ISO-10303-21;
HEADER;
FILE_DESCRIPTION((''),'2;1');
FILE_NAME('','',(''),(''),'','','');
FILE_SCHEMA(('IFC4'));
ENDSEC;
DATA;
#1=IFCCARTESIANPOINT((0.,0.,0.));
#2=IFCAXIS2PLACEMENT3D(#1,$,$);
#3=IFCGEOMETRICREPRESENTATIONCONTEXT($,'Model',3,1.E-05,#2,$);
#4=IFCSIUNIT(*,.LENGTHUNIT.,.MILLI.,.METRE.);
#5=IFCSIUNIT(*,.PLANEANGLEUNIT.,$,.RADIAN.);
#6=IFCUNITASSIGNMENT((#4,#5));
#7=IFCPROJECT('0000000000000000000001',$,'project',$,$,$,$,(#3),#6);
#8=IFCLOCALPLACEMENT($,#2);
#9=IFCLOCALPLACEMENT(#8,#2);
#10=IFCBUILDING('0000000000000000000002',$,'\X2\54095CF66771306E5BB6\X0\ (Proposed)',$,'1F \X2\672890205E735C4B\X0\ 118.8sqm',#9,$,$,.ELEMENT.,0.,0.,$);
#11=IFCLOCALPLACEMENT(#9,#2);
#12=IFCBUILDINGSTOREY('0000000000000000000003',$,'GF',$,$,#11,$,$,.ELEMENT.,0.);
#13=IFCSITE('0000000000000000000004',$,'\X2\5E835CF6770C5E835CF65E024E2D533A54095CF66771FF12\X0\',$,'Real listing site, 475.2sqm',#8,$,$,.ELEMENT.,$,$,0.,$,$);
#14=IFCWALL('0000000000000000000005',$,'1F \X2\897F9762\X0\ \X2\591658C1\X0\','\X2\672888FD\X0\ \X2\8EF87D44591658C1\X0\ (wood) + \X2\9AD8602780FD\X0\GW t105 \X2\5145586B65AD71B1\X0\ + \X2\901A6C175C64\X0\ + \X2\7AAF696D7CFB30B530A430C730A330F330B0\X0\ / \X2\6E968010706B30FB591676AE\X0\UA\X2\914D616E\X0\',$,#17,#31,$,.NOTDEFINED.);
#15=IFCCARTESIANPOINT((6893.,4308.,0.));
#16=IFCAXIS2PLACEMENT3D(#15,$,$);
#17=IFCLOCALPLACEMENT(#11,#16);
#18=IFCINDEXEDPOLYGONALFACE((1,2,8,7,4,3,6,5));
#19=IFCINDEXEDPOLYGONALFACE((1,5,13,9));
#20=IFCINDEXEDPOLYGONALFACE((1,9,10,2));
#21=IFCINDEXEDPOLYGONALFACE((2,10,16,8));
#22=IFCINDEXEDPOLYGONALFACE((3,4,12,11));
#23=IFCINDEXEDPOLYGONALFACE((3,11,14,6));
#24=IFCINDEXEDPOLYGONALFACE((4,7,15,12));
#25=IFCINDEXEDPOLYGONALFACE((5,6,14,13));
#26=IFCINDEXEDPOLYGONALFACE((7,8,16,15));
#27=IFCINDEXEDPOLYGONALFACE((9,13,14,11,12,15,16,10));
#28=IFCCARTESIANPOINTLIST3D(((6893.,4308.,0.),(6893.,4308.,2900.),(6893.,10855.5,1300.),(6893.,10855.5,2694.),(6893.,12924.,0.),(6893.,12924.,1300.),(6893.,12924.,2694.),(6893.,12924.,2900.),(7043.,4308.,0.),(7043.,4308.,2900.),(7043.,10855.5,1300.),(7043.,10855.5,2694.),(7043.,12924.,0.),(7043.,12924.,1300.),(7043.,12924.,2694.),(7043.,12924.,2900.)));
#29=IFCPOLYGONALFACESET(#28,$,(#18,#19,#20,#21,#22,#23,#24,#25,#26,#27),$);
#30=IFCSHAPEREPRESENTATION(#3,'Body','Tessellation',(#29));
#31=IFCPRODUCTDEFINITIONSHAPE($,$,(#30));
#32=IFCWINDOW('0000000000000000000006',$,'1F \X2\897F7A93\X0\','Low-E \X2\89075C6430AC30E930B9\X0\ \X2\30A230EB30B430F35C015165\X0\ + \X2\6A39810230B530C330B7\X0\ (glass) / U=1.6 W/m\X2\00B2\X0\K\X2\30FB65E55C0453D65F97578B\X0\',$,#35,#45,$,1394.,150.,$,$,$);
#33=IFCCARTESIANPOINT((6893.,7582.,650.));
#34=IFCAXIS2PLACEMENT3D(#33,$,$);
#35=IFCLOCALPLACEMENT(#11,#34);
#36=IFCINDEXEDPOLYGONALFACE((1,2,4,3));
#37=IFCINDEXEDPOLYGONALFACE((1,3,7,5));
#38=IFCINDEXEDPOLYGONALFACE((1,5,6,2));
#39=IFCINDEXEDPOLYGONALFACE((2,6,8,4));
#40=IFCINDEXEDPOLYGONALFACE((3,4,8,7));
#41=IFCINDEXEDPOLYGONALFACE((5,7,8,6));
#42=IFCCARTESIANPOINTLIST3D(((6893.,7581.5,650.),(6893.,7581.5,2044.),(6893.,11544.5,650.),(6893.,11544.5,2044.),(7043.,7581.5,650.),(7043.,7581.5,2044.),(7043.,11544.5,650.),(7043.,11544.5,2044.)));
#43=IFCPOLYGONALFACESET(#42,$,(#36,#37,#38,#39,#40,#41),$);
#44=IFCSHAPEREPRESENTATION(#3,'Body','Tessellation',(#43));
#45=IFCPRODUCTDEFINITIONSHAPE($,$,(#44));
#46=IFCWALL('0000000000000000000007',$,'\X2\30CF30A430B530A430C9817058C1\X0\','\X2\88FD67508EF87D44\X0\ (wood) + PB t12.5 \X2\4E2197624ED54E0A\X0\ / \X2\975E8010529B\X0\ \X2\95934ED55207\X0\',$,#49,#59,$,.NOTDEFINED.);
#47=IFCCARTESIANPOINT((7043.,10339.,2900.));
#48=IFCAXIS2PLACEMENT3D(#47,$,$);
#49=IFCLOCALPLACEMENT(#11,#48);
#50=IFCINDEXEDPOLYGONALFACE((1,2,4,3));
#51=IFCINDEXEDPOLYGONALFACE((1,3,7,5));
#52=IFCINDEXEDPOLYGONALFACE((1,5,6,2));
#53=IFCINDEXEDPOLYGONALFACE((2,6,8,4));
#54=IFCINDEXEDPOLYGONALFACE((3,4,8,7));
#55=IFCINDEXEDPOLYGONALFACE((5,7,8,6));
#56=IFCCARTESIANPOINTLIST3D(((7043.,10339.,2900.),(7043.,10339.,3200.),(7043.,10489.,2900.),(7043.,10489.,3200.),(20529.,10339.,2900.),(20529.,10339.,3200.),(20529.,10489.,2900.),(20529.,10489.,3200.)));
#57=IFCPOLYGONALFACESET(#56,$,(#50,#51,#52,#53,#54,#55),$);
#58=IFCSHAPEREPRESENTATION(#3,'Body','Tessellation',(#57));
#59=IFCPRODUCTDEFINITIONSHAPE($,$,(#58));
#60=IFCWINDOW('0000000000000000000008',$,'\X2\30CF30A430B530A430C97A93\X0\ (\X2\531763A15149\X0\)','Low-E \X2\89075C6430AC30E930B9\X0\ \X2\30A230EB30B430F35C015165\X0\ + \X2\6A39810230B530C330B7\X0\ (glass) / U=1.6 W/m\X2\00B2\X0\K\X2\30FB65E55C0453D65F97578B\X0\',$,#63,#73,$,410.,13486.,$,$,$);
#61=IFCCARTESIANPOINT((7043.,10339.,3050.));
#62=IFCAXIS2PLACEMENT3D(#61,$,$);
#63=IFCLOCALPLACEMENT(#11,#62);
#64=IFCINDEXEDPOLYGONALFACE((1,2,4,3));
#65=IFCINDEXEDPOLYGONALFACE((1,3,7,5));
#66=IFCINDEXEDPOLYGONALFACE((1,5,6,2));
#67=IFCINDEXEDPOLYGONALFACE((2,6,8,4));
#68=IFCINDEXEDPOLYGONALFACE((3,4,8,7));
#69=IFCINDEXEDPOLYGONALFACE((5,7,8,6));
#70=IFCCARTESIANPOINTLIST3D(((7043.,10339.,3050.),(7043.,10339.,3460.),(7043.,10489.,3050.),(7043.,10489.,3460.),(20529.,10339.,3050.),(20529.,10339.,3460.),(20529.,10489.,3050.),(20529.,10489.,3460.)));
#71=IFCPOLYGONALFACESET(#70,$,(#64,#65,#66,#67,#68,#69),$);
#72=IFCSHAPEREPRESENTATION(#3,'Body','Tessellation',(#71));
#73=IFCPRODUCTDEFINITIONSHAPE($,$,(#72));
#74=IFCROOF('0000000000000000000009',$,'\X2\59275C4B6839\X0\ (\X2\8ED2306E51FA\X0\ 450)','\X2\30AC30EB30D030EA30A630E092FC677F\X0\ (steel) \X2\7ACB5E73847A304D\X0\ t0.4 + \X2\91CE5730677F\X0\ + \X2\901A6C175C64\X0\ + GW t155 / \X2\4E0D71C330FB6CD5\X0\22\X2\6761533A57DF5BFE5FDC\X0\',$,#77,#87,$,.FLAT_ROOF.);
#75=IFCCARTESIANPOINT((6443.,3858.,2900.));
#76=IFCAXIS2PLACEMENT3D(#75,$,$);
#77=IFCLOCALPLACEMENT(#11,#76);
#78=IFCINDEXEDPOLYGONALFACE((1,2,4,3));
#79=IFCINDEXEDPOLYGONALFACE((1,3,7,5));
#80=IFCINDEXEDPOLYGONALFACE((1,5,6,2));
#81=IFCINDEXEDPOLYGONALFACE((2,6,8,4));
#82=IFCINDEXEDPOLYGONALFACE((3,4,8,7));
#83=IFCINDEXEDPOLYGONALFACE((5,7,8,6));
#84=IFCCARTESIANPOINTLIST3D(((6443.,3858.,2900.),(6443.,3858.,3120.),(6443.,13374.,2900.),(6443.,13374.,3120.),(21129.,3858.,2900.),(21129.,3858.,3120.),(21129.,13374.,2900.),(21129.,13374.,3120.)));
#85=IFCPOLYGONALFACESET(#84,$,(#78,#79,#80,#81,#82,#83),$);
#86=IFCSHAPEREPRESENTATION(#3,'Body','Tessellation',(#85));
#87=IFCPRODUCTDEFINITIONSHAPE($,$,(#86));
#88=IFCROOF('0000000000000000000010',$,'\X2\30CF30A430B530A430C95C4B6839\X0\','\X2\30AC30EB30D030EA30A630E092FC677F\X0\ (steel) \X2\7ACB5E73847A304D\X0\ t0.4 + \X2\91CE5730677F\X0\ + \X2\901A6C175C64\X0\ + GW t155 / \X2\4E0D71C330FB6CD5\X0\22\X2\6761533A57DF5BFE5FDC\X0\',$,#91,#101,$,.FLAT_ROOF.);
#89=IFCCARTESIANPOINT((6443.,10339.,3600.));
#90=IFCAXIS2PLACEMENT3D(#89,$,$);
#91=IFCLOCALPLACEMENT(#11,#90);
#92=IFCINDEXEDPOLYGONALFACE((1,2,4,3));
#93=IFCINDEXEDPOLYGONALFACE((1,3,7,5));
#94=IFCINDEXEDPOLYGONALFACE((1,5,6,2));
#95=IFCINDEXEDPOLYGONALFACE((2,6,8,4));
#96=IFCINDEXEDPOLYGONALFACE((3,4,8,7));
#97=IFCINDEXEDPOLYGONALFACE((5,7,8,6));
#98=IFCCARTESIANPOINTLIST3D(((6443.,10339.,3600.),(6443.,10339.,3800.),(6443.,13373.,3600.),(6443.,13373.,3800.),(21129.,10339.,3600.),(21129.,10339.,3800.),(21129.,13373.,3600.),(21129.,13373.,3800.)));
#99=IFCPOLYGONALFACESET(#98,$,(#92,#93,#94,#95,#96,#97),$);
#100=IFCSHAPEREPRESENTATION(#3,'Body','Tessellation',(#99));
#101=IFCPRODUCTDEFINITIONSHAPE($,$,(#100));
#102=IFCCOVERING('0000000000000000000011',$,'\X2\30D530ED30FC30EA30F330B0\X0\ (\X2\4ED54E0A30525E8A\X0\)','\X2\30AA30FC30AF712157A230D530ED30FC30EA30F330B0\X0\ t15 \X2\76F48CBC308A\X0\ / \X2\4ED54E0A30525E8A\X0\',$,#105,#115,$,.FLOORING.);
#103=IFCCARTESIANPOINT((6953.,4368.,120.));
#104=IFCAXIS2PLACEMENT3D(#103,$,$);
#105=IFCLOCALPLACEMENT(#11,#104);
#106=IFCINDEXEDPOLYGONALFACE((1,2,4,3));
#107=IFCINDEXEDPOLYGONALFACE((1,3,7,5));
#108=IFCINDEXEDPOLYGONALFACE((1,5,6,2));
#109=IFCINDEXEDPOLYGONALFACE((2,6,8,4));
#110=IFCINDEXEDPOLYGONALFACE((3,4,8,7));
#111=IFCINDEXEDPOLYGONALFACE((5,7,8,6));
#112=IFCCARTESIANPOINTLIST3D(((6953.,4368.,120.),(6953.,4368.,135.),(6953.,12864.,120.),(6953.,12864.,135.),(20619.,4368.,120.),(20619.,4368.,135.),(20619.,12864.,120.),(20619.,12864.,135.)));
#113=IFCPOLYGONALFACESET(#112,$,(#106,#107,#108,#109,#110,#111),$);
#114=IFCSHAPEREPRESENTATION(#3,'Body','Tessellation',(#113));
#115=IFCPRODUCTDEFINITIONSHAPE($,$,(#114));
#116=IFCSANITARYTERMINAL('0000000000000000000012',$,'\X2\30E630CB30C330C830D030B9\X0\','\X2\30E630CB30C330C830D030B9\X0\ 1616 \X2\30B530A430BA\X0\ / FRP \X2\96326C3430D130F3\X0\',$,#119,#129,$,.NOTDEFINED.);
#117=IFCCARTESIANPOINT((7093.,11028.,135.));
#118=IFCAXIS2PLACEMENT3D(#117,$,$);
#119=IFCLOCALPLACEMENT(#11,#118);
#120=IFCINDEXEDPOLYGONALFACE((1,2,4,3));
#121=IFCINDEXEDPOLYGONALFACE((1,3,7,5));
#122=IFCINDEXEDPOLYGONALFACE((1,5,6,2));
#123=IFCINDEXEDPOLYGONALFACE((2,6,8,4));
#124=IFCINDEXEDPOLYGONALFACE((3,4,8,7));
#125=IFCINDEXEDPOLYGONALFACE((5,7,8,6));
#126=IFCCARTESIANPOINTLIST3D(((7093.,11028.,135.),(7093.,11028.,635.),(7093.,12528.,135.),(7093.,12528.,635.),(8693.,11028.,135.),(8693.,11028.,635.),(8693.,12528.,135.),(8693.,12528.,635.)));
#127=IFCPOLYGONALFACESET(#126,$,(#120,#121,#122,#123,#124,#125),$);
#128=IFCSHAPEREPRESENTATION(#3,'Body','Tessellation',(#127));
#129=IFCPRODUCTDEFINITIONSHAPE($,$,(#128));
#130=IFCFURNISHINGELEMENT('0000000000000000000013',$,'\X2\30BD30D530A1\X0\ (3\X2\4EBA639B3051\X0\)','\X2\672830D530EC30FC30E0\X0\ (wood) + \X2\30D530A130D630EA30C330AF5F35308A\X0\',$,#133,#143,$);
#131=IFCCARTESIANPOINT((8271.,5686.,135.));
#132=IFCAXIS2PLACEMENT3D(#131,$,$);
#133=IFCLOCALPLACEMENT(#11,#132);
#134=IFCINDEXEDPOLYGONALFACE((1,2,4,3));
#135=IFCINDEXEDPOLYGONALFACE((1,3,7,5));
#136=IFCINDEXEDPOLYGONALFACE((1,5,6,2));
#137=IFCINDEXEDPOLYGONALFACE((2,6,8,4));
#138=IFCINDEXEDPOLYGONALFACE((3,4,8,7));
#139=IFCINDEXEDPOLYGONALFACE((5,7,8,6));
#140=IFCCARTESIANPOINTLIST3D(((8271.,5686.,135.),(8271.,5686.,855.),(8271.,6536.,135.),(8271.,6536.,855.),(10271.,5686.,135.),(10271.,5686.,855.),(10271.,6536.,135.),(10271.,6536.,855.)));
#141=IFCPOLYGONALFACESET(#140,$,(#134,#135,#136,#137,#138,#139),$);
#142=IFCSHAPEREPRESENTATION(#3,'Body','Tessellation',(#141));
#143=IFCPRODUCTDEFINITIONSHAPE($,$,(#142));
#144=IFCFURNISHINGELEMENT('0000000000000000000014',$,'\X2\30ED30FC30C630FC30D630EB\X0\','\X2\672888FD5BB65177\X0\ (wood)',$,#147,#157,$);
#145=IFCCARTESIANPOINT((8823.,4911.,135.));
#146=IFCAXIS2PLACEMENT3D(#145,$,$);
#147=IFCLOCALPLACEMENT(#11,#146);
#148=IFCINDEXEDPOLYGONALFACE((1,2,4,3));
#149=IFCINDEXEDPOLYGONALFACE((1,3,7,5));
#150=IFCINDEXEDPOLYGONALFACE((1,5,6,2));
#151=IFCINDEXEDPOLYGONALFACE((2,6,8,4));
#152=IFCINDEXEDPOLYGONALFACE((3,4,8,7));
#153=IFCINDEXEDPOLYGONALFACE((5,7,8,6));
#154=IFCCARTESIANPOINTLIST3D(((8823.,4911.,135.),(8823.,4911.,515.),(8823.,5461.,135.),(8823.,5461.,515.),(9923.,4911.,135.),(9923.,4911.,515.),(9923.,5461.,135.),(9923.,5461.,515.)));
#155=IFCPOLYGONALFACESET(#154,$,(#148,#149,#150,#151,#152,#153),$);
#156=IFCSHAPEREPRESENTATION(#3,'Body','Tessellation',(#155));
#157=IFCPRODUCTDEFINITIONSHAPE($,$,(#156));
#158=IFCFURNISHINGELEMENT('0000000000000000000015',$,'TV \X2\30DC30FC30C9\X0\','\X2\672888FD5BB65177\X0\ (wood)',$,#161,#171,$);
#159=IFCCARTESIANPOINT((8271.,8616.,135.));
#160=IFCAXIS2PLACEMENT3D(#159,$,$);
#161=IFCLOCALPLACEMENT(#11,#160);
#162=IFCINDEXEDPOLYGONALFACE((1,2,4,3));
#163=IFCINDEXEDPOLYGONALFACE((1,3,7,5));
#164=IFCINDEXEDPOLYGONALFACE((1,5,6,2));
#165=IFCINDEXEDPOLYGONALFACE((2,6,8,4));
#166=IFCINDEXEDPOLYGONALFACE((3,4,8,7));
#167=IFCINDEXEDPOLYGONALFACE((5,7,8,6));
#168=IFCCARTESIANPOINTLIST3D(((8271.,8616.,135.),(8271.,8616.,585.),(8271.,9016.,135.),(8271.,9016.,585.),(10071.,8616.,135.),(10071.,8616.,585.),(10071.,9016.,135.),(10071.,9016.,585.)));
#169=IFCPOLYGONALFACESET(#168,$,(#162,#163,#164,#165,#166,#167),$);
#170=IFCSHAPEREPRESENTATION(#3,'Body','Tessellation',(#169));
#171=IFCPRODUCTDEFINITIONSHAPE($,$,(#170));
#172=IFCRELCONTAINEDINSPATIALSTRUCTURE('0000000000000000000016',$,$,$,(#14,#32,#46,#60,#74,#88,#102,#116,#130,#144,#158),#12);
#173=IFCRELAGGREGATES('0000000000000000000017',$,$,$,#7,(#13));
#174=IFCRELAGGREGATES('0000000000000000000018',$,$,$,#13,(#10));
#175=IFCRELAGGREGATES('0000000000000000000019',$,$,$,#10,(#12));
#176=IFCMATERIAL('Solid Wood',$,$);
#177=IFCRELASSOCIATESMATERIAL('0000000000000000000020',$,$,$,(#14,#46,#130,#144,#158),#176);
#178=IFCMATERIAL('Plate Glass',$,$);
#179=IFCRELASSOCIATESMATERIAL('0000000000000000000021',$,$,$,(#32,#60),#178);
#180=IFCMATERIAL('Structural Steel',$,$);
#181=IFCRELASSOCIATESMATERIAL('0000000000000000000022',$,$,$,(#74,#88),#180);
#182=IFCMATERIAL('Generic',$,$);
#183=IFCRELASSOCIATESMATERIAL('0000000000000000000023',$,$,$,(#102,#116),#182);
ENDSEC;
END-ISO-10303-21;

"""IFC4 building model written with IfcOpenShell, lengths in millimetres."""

from ifc_helpers import new_model, si_unit, frame, frame_2d, origin, place, context, project, spatial, rectangle, extrude, material, element, fill, save


model = new_model("IFC4")

# Units and contexts
model_context = context("Model", 3, precision=1e-05, world=origin())
ifc_project = project(units=[si_unit("LENGTHUNIT", "METRE", prefix="MILLI"), si_unit("PLANEANGLEUNIT", "RADIAN")], contexts=[model_context])

# Site, building, storey
site_placement = place(None, origin())
site = spatial("IfcSite", under=ifc_project, at=site_placement, Name="広島県広島市中区吉島東２", ObjectType="Real listing site, 475.2sqm", CompositionType="ELEMENT", RefElevation=0.0)
building_placement = place(site_placement, origin())
building = spatial("IfcBuilding", under=site, at=building_placement, Name="吉島東の家 (Proposed)", ObjectType="1F 木造平屋 118.8sqm", CompositionType="ELEMENT", ElevationOfRefHeight=0.0, ElevationOfTerrain=0.0)
storey_placement = place(building_placement, origin())
storey = spatial("IfcBuildingStorey", under=building, at=storey_placement, Name="GF", CompositionType="ELEMENT", Elevation=0.0)

# Shared definitions
ifc_material_1 = material(Name="Solid Wood")

# Shared definitions
ifc_material_2 = material(Name="Plate Glass")

# Wall, opening, window
wall_1_placement = place(storey_placement, frame((6893.0, 4308.0, 0.0)))
wall_1 = element("IfcWall", 1, at=wall_1_placement, inside=storey, material=ifc_material_1, Name="1F 西面 外壁", Description="木製 軸組外壁 (wood) + 高性能GW t105 充填断熱 + 通気層 + 窯業系サイディング / 準耐火・外皮UA配慮", PredefinedType="NOTDEFINED", context=model_context, shape_type="SweptSolid", body=[
    extrude(rectangle(XDim=150.0, YDim=8616.0, at=frame_2d((75.0, 4308.0))), frame((6893.0, 4308.0, 0.0)), (0.0, 0.0, 1.0), 2900.0),
])
opening_1_placement = place(storey_placement, frame((6893.0, 7582.0, 650.0)))
opening_1 = element("IfcOpeningElement", 2, at=opening_1_placement, cuts=wall_1, PredefinedType="NOTDEFINED", context=model_context, shape_type="SweptSolid", body=[
    extrude(rectangle(XDim=150.0, YDim=3963.0, at=frame_2d((75.0, 1981.0))), frame((6893.0, 7582.0, 650.0)), (0.0, 0.0, 1.0), 1394.0),
])
window_1_placement = place(storey_placement, frame((6893.0, 7582.0, 650.0)))
window_1 = element("IfcWindow", 3, at=window_1_placement, inside=storey, material=ifc_material_2, Name="1F 西窓", Description="Low-E 複層ガラス アルゴン封入 + 樹脂サッシ (glass) / U=1.6 W/m²K・日射取得型", OverallHeight=1394.0, OverallWidth=150.0, context=model_context, shape_type="SweptSolid", body=[
    extrude(rectangle(XDim=150.0, YDim=3963.0, at=frame_2d((75.0, 1981.0))), frame((6893.0, 7582.0, 650.0)), (0.0, 0.0, 1.0), 1394.0),
])
fill(opening_1, window_1)

# Wall, opening, window
wall_2_placement = place(storey_placement, frame((7043.0, 10339.0, 2900.0)))
wall_2 = element("IfcWall", 4, at=wall_2_placement, inside=storey, material=ifc_material_1, Name="ハイサイド腰壁", Description="製材軸組 (wood) + PB t12.5 両面仕上 / 非耐力 間仕切", PredefinedType="NOTDEFINED", context=model_context, shape_type="SweptSolid", body=[
    extrude(rectangle(XDim=13486.0, YDim=150.0, at=frame_2d((6743.0, 75.0))), frame((7043.0, 10339.0, 2900.0)), (0.0, 0.0, 1.0), 700.0),
])
opening_2_placement = place(storey_placement, frame((7043.0, 10339.0, 3050.0)))
opening_2 = element("IfcOpeningElement", 5, at=opening_2_placement, cuts=wall_2, PredefinedType="NOTDEFINED", context=model_context, shape_type="SweptSolid", body=[
    extrude(rectangle(XDim=13486.0, YDim=150.0, at=frame_2d((6743.0, 75.0))), frame((7043.0, 10339.0, 3050.0)), (0.0, 0.0, 1.0), 410.0),
])
window_2_placement = place(storey_placement, frame((7043.0, 10339.0, 3050.0)))
window_2 = element("IfcWindow", 6, at=window_2_placement, inside=storey, material=ifc_material_2, Name="ハイサイド窓 (北採光)", Description="Low-E 複層ガラス アルゴン封入 + 樹脂サッシ (glass) / U=1.6 W/m²K・日射取得型", OverallHeight=410.0, OverallWidth=13486.0, context=model_context, shape_type="SweptSolid", body=[
    extrude(rectangle(XDim=13486.0, YDim=150.0, at=frame_2d((6743.0, 75.0))), frame((7043.0, 10339.0, 3050.0)), (0.0, 0.0, 1.0), 410.0),
])
fill(opening_2, window_2)

# Roofs
ifc_material_3 = material(Name="Structural Steel")
roof_1_placement = place(storey_placement, frame((6443.0, 3858.0, 2900.0)))
element("IfcRoof", 7, at=roof_1_placement, inside=storey, material=ifc_material_3, Name="大屋根 (軒の出 450)", Description="ガルバリウム鋼板 (steel) 立平葺き t0.4 + 野地板 + 通気層 + GW t155 / 不燃・法22条区域対応", PredefinedType="FLAT_ROOF", context=model_context, shape_type="SweptSolid", body=[
    extrude(rectangle(XDim=14686.0, YDim=9516.0, at=frame_2d((7343.0, 4758.0))), frame((6443.0, 3858.0, 2900.0)), (0.0, 0.0, 1.0), 220.0),
])
roof_2_placement = place(storey_placement, frame((6443.0, 10339.0, 3600.0)))
element("IfcRoof", 8, at=roof_2_placement, inside=storey, material=ifc_material_3, Name="ハイサイド屋根", Description="ガルバリウム鋼板 (steel) 立平葺き t0.4 + 野地板 + 通気層 + GW t155 / 不燃・法22条区域対応", PredefinedType="FLAT_ROOF", context=model_context, shape_type="SweptSolid", body=[
    extrude(rectangle(XDim=14686.0, YDim=3034.0, at=frame_2d((7343.0, 1517.0))), frame((6443.0, 10339.0, 3600.0)), (0.0, 0.0, 1.0), 200.0),
])

# Covering
ifc_material_4 = material(Name="Generic")
covering_placement = place(storey_placement, frame((6953.0, 4368.0, 120.0)))
element("IfcCovering", 9, at=covering_placement, inside=storey, material=ifc_material_4, Name="フローリング (仕上げ床)", Description="オーク無垢フローリング t15 直貼り / 仕上げ床", PredefinedType="FLOORING", context=model_context, shape_type="SweptSolid", body=[
    extrude(rectangle(XDim=13666.0, YDim=8496.0, at=frame_2d((6833.0, 4248.0))), frame((6953.0, 4368.0, 120.0)), (0.0, 0.0, 1.0), 15.0),
])

# Sanitary terminal
sanitary_terminal_placement = place(storey_placement, frame((7093.0, 11028.0, 135.0)))
element("IfcSanitaryTerminal", 10, at=sanitary_terminal_placement, inside=storey, material=ifc_material_4, Name="ユニットバス", Description="ユニットバス 1616 サイズ / FRP 防水パン", PredefinedType="NOTDEFINED", context=model_context, shape_type="SweptSolid", body=[
    extrude(rectangle(XDim=1600.0, YDim=1500.0, at=frame_2d((800.0, 750.0))), frame((7093.0, 11028.0, 135.0)), (0.0, 0.0, 1.0), 500.0),
])

# Furnishing elements
furnishing_1_placement = place(storey_placement, frame((8271.0, 5686.0, 135.0)))
element("IfcFurnishingElement", 11, at=furnishing_1_placement, inside=storey, material=ifc_material_1, Name="ソファ (3人掛け)", Description="木フレーム (wood) + ファブリック張り", context=model_context, shape_type="SweptSolid", body=[
    extrude(rectangle(XDim=2000.0, YDim=850.0, at=frame_2d((1000.0, 425.0))), frame((8271.0, 5686.0, 135.0)), (0.0, 0.0, 1.0), 720.0),
])
furnishing_2_placement = place(storey_placement, frame((8823.0, 4911.0, 135.0)))
element("IfcFurnishingElement", 12, at=furnishing_2_placement, inside=storey, material=ifc_material_1, Name="ローテーブル", Description="木製家具 (wood)", context=model_context, shape_type="SweptSolid", body=[
    extrude(rectangle(XDim=1100.0, YDim=550.0, at=frame_2d((550.0, 275.0))), frame((8823.0, 4911.0, 135.0)), (0.0, 0.0, 1.0), 380.0),
])
furnishing_3_placement = place(storey_placement, frame((8271.0, 8616.0, 135.0)))
element("IfcFurnishingElement", 13, at=furnishing_3_placement, inside=storey, material=ifc_material_1, Name="TV ボード", Description="木製家具 (wood)", context=model_context, shape_type="SweptSolid", body=[
    extrude(rectangle(XDim=1800.0, YDim=400.0, at=frame_2d((900.0, 200.0))), frame((8271.0, 8616.0, 135.0)), (0.0, 0.0, 1.0), 450.0),
])

save(model, "model.ifc")
